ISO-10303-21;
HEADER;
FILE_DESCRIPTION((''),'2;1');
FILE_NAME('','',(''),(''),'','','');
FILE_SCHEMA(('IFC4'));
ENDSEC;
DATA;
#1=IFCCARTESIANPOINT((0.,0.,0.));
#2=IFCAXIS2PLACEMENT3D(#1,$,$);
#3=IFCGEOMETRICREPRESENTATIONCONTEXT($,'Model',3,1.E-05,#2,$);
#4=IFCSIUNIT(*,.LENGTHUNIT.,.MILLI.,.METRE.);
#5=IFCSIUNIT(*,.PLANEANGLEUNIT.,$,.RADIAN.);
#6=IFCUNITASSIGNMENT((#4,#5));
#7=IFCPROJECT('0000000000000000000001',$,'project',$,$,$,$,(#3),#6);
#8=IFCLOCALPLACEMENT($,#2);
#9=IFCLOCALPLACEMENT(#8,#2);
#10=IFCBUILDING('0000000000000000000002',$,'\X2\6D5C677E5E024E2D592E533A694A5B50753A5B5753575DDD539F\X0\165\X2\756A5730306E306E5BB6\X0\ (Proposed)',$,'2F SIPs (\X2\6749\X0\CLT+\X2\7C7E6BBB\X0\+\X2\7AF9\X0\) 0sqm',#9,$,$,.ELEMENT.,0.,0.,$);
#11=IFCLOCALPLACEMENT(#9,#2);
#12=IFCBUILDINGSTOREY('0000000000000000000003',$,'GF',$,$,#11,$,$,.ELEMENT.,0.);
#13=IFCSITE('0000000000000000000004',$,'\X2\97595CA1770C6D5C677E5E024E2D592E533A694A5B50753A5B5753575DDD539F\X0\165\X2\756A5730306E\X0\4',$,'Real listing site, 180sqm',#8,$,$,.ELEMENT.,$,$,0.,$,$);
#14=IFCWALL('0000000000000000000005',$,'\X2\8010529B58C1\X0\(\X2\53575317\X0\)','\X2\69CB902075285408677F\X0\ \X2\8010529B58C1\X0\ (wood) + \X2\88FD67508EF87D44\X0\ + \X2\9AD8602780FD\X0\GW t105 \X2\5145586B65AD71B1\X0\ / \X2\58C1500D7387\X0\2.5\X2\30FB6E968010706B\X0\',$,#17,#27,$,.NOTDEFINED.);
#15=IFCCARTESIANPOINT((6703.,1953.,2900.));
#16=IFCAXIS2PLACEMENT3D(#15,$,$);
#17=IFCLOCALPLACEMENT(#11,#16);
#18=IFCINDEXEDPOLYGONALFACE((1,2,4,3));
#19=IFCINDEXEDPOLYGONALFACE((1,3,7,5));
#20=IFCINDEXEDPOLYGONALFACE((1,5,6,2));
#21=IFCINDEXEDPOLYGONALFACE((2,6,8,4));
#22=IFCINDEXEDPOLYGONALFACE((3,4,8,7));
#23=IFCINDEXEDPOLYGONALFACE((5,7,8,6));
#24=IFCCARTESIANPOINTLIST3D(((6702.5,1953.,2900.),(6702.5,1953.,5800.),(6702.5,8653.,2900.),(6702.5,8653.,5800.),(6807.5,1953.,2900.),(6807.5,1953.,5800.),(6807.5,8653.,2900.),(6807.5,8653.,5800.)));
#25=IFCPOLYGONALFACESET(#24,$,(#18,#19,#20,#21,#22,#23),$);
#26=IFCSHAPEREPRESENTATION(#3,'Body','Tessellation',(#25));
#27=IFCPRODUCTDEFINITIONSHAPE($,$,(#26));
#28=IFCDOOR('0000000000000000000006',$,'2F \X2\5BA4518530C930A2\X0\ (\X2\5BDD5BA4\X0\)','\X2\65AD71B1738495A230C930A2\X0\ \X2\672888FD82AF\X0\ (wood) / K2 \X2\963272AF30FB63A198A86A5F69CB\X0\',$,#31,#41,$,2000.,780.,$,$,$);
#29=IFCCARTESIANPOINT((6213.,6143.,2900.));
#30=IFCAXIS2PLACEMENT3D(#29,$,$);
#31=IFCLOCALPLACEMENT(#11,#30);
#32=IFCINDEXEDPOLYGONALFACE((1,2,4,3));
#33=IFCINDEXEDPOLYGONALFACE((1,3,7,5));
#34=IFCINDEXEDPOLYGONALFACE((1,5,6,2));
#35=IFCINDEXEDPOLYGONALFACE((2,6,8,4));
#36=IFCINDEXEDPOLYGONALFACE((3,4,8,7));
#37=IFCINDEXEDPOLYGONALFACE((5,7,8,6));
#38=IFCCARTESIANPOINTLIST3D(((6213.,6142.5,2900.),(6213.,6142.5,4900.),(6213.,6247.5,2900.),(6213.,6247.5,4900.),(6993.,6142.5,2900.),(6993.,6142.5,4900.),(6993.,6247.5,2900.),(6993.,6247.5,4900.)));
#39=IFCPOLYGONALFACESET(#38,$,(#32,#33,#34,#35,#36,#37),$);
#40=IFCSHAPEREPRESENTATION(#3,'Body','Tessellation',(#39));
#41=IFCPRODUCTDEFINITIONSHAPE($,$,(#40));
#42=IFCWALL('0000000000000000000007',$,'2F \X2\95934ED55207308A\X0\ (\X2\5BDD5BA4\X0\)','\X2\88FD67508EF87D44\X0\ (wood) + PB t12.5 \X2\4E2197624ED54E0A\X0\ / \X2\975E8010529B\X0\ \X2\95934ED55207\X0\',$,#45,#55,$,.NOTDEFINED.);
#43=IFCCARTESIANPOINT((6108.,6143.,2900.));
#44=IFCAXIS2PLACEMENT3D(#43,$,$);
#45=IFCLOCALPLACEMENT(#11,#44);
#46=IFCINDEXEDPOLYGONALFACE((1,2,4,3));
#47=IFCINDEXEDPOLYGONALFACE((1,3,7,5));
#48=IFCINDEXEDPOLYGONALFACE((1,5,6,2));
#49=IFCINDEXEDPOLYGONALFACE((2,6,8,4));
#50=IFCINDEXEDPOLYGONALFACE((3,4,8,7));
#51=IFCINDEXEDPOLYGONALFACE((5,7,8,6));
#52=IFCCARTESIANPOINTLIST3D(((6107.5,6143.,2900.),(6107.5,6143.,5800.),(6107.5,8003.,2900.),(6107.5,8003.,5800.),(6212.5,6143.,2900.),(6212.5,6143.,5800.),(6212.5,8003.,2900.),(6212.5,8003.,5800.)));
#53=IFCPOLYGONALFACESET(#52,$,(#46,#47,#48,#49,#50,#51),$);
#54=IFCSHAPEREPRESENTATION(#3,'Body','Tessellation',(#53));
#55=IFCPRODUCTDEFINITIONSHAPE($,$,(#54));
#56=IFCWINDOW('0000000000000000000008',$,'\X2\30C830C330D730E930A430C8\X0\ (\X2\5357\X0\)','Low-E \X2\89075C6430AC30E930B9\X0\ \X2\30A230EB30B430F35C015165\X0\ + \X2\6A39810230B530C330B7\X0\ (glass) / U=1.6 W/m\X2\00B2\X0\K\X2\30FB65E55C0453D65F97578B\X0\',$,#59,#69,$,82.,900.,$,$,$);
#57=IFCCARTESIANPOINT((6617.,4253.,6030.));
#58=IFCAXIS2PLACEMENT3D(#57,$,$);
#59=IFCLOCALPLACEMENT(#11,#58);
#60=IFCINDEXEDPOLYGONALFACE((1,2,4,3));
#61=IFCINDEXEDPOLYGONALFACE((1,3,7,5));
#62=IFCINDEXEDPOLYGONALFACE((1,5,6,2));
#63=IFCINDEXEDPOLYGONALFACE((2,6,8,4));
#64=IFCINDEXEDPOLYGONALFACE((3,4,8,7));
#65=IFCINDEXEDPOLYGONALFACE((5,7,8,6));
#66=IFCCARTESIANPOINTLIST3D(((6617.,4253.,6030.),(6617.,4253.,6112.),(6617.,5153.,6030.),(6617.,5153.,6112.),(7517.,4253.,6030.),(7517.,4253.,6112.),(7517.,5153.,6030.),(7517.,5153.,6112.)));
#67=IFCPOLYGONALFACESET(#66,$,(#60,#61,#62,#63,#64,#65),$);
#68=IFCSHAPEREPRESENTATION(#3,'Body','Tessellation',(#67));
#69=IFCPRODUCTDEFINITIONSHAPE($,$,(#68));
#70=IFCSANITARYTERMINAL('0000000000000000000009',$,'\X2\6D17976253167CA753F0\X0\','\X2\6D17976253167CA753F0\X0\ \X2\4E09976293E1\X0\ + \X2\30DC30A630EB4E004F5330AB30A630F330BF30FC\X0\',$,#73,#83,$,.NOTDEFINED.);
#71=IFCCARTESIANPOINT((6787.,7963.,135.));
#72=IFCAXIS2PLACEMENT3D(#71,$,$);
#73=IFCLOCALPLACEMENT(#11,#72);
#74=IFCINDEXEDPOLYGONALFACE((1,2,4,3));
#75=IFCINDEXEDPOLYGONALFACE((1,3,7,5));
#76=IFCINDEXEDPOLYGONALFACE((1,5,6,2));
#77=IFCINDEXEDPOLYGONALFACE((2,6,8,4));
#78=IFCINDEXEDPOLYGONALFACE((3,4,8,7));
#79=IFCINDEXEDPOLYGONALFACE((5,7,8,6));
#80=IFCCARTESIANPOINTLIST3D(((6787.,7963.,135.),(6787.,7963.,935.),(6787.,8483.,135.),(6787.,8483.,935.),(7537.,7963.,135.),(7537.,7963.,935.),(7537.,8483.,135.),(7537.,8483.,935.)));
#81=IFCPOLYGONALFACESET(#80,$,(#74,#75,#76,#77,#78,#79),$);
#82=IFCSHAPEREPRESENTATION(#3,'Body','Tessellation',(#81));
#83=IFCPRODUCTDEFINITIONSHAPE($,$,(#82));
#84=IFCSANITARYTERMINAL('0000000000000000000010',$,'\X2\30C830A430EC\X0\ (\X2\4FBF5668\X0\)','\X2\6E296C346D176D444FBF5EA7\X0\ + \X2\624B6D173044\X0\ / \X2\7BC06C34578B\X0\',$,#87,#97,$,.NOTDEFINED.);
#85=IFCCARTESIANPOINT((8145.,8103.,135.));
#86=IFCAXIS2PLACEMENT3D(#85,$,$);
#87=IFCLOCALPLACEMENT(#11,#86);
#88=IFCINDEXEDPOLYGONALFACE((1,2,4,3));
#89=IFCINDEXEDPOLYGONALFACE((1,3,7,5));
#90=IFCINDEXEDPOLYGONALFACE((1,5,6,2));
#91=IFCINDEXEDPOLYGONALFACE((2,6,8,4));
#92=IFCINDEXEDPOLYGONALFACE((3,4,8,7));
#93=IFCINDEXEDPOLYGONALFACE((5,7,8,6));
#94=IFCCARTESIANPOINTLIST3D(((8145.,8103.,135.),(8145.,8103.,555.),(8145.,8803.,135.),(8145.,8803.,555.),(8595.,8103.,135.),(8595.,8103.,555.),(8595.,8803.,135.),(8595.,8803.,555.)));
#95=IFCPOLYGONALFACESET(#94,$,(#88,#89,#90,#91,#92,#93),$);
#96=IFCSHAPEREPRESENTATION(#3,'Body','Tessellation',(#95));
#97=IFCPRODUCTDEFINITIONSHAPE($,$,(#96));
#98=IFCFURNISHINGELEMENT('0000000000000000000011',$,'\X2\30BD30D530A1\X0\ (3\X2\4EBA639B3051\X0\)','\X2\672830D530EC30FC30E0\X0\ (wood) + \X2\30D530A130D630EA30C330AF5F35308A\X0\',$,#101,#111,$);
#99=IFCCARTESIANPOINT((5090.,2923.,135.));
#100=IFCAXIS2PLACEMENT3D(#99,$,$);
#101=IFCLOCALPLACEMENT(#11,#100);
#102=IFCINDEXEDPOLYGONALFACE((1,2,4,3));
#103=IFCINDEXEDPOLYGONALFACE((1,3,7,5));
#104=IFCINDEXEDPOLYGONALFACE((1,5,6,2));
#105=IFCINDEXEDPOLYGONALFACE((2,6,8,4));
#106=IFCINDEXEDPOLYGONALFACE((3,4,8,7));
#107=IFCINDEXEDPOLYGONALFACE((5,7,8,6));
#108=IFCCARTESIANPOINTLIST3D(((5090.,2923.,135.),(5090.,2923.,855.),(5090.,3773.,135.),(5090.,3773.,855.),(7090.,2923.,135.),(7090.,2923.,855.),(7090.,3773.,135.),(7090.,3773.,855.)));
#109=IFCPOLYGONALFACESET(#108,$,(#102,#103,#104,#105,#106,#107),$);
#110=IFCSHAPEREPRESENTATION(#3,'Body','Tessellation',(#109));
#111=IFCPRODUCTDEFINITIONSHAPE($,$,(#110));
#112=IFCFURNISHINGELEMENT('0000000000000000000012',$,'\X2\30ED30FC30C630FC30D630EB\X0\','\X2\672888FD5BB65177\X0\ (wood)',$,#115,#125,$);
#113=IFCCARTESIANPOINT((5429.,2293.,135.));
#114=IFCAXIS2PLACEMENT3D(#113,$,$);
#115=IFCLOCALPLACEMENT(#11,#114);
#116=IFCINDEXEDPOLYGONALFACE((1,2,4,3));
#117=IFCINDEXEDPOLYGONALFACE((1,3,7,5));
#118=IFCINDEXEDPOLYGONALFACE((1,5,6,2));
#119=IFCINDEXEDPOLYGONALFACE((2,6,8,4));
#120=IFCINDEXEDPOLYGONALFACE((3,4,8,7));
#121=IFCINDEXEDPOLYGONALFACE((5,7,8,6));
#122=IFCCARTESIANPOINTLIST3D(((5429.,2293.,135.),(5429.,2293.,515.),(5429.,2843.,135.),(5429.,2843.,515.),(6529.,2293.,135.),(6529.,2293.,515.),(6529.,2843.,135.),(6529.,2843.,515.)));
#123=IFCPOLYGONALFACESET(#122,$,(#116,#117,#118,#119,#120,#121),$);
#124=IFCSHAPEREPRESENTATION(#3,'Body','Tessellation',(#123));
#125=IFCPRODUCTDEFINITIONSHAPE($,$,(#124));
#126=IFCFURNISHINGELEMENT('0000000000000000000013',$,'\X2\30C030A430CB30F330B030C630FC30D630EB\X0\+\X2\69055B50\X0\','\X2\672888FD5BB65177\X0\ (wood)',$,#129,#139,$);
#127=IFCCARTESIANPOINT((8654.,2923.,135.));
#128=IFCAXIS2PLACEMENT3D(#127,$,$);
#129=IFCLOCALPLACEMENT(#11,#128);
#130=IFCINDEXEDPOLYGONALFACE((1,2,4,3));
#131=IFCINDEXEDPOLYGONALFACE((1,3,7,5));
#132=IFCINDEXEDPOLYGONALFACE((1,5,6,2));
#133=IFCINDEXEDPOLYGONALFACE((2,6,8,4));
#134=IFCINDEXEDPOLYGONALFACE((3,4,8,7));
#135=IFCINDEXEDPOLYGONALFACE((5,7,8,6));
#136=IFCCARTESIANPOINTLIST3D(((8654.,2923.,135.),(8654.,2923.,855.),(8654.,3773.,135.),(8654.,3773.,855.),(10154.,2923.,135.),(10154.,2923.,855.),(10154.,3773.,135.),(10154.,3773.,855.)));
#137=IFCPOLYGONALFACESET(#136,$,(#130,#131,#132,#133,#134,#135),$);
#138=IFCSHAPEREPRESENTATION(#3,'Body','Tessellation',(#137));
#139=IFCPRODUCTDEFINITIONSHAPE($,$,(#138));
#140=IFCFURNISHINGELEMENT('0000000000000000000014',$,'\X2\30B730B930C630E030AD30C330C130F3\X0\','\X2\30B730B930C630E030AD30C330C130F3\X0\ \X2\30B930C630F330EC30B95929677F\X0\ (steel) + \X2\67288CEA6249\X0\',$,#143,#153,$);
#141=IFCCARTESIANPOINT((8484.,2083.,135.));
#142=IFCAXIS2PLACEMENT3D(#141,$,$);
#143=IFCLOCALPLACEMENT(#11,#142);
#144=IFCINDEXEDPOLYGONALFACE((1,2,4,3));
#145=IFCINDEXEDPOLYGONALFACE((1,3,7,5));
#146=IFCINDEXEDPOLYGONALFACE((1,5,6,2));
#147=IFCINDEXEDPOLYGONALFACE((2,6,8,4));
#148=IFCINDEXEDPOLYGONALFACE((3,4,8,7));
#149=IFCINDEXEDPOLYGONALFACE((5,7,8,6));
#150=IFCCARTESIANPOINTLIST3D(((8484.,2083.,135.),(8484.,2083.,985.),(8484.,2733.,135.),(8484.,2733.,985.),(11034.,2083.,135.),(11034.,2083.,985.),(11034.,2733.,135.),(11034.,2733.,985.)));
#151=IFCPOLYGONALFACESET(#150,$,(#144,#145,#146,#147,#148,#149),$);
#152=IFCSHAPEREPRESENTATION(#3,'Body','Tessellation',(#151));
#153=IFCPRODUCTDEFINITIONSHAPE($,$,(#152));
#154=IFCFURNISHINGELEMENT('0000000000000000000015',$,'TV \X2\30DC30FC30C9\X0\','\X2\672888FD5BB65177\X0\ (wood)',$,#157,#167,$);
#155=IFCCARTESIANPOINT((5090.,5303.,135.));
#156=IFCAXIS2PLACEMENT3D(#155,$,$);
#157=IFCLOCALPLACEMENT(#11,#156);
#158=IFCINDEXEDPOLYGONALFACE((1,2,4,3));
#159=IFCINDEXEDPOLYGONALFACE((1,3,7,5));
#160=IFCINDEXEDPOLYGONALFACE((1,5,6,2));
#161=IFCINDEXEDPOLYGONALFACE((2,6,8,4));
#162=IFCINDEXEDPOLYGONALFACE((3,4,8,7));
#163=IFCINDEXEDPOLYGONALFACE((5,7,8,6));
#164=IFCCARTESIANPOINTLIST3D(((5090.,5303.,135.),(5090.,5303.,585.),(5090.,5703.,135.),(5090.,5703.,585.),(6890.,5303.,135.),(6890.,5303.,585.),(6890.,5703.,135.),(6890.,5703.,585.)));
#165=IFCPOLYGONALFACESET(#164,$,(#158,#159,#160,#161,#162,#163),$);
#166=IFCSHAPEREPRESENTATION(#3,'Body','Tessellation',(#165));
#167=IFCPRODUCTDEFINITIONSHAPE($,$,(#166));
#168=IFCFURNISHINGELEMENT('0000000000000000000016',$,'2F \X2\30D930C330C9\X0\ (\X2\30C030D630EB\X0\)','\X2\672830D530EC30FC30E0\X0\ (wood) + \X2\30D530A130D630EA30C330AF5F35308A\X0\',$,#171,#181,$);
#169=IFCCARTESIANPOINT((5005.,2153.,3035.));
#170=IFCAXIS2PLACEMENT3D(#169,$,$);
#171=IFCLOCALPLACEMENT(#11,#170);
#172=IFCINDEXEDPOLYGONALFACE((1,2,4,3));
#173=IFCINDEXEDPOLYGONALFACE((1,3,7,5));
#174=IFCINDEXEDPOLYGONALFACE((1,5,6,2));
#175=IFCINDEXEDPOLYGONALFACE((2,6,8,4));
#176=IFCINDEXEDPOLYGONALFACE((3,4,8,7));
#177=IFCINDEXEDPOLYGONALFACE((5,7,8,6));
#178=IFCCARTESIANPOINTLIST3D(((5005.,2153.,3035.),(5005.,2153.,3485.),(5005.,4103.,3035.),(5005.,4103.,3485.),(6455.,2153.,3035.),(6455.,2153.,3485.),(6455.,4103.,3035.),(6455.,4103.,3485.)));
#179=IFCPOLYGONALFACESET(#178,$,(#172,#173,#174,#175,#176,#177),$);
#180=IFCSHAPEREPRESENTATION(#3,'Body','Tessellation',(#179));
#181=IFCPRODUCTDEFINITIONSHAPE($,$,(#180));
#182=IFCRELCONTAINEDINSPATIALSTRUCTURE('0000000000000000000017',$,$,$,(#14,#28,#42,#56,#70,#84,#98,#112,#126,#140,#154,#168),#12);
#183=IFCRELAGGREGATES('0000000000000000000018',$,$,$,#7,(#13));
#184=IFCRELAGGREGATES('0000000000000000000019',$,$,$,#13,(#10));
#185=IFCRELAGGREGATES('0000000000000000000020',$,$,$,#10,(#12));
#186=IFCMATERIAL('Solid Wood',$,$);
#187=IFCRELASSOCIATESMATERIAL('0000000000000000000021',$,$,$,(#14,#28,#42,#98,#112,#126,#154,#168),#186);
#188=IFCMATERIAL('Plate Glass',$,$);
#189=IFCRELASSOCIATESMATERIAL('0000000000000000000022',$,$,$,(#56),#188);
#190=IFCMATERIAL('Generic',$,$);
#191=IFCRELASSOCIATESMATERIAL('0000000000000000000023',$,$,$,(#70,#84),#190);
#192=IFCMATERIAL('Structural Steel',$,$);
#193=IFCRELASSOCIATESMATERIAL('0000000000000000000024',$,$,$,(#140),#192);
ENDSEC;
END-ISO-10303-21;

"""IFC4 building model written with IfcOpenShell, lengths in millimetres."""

from ifc_helpers import new_model, si_unit, frame, frame_2d, origin, place, context, project, spatial, rectangle, extrude, material, element, fill, save


model = new_model("IFC4")

# Units and contexts
model_context = context("Model", 3, precision=1e-05, world=origin())
ifc_project = project(units=[si_unit("LENGTHUNIT", "METRE", prefix="MILLI"), si_unit("PLANEANGLEUNIT", "RADIAN")], contexts=[model_context])

# Site, building, storey
site_placement = place(None, origin())
site = spatial("IfcSite", under=ifc_project, at=site_placement, Name="静岡県浜松市中央区楊子町字南川原165番地の4", ObjectType="Real listing site, 180sqm", CompositionType="ELEMENT", RefElevation=0.0)
building_placement = place(site_placement, origin())
building = spatial("IfcBuilding", under=site, at=building_placement, Name="浜松市中央区楊子町字南川原165番地のの家 (Proposed)", ObjectType="2F SIPs (杉CLT+籾殻+竹) 0sqm", CompositionType="ELEMENT", ElevationOfRefHeight=0.0, ElevationOfTerrain=0.0)
storey_placement = place(building_placement, origin())
storey = spatial("IfcBuildingStorey", under=building, at=storey_placement, Name="GF", CompositionType="ELEMENT", Elevation=0.0)

# Shared definitions
ifc_material_1 = material(Name="Solid Wood")

# Wall, opening, door
wall_1_placement = place(storey_placement, frame((6703.0, 1953.0, 2900.0)))
wall_1 = element("IfcWall", 1, at=wall_1_placement, inside=storey, material=ifc_material_1, Name="耐力壁(南北)", Description="構造用合板 耐力壁 (wood) + 製材軸組 + 高性能GW t105 充填断熱 / 壁倍率2.5・準耐火", PredefinedType="NOTDEFINED", context=model_context, shape_type="SweptSolid", body=[
    extrude(rectangle(XDim=105.0, YDim=6700.0, at=frame_2d((52.0, 3350.0))), frame((6703.0, 1953.0, 2900.0)), (0.0, 0.0, 1.0), 2900.0),
])
opening_1_placement = place(storey_placement, frame((6213.0, 6143.0, 2900.0)))
opening_1 = element("IfcOpeningElement", 2, at=opening_1_placement, cuts=wall_1, PredefinedType="NOTDEFINED", context=model_context, shape_type="SweptSolid", body=[
    extrude(rectangle(XDim=780.0, YDim=105.0, at=frame_2d((390.0, 52.0))), frame((6213.0, 6143.0, 2900.0)), (0.0, 0.0, 1.0), 2000.0),
])
door_1_placement = place(storey_placement, frame((6213.0, 6143.0, 2900.0)))
door_1 = element("IfcDoor", 3, at=door_1_placement, inside=storey, material=ifc_material_1, Name="2F 室内ドア (寝室)", Description="断熱玄関ドア 木製芯 (wood) / K2 防犯・採風機構", OverallHeight=2000.0, OverallWidth=780.0, context=model_context, shape_type="SweptSolid", body=[
    extrude(rectangle(XDim=780.0, YDim=105.0, at=frame_2d((390.0, 52.0))), frame((6213.0, 6143.0, 2900.0)), (0.0, 0.0, 1.0), 2000.0),
])
fill(opening_1, door_1)

# Wall
wall_2_placement = place(storey_placement, frame((6108.0, 6143.0, 2900.0)))
element("IfcWall", 4, at=wall_2_placement, inside=storey, material=ifc_material_1, Name="2F 間仕切り (寝室)", Description="製材軸組 (wood) + PB t12.5 両面仕上 / 非耐力 間仕切", PredefinedType="NOTDEFINED", context=model_context, shape_type="SweptSolid", body=[
    extrude(rectangle(XDim=105.0, YDim=1860.0, at=frame_2d((52.0, 930.0))), frame((6108.0, 6143.0, 2900.0)), (0.0, 0.0, 1.0), 2900.0),
])

# Window
ifc_material_2 = material(Name="Plate Glass")
window_placement = place(storey_placement, frame((6617.0, 4253.0, 6030.0)))
element("IfcWindow", 5, at=window_placement, inside=storey, material=ifc_material_2, Name="トップライト (南)", Description="Low-E 複層ガラス アルゴン封入 + 樹脂サッシ (glass) / U=1.6 W/m²K・日射取得型", OverallHeight=82.0, OverallWidth=900.0, context=model_context, shape_type="SweptSolid", body=[
    extrude(rectangle(XDim=900.0, YDim=900.0, at=frame_2d((450.0, 450.0))), frame((6617.0, 4253.0, 6030.0)), (0.0, 0.0, 1.0), 82.0),
])

# Sanitary terminals
ifc_material_3 = material(Name="Generic")
sanitary_terminal_1_placement = place(storey_placement, frame((6787.0, 7963.0, 135.0)))
element("IfcSanitaryTerminal", 6, at=sanitary_terminal_1_placement, inside=storey, material=ifc_material_3, Name="洗面化粧台", Description="洗面化粧台 三面鏡 + ボウル一体カウンター", PredefinedType="NOTDEFINED", context=model_context, shape_type="SweptSolid", body=[
    extrude(rectangle(XDim=750.0, YDim=520.0, at=frame_2d((375.0, 260.0))), frame((6787.0, 7963.0, 135.0)), (0.0, 0.0, 1.0), 800.0),
])
sanitary_terminal_2_placement = place(storey_placement, frame((8145.0, 8103.0, 135.0)))
element("IfcSanitaryTerminal", 7, at=sanitary_terminal_2_placement, inside=storey, material=ifc_material_3, Name="トイレ (便器)", Description="温水洗浄便座 + 手洗い / 節水型", PredefinedType="NOTDEFINED", context=model_context, shape_type="SweptSolid", body=[
    extrude(rectangle(XDim=450.0, YDim=700.0, at=frame_2d((225.0, 350.0))), frame((8145.0, 8103.0, 135.0)), (0.0, 0.0, 1.0), 420.0),
])

# Furnishing elements
furnishing_1_placement = place(storey_placement, frame((5090.0, 2923.0, 135.0)))
element("IfcFurnishingElement", 8, at=furnishing_1_placement, inside=storey, material=ifc_material_1, Name="ソファ (3人掛け)", Description="木フレーム (wood) + ファブリック張り", context=model_context, shape_type="SweptSolid", body=[
    extrude(rectangle(XDim=2000.0, YDim=850.0, at=frame_2d((1000.0, 425.0))), frame((5090.0, 2923.0, 135.0)), (0.0, 0.0, 1.0), 720.0),
])
furnishing_2_placement = place(storey_placement, frame((5429.0, 2293.0, 135.0)))
element("IfcFurnishingElement", 9, at=furnishing_2_placement, inside=storey, material=ifc_material_1, Name="ローテーブル", Description="木製家具 (wood)", context=model_context, shape_type="SweptSolid", body=[
    extrude(rectangle(XDim=1100.0, YDim=550.0, at=frame_2d((550.0, 275.0))), frame((5429.0, 2293.0, 135.0)), (0.0, 0.0, 1.0), 380.0),
])
furnishing_3_placement = place(storey_placement, frame((8654.0, 2923.0, 135.0)))
element("IfcFurnishingElement", 10, at=furnishing_3_placement, inside=storey, material=ifc_material_1, Name="ダイニングテーブル+椅子", Description="木製家具 (wood)", context=model_context, shape_type="SweptSolid", body=[
    extrude(rectangle(XDim=1500.0, YDim=850.0, at=frame_2d((750.0, 425.0))), frame((8654.0, 2923.0, 135.0)), (0.0, 0.0, 1.0), 720.0),
])
ifc_material_4 = material(Name="Structural Steel")
furnishing_4_placement = place(storey_placement, frame((8484.0, 2083.0, 135.0)))
element("IfcFurnishingElement", 11, at=furnishing_4_placement, inside=storey, material=ifc_material_4, Name="システムキッチン", Description="システムキッチン ステンレス天板 (steel) + 木質扉", context=model_context, shape_type="SweptSolid", body=[
    extrude(rectangle(XDim=2550.0, YDim=650.0, at=frame_2d((1275.0, 325.0))), frame((8484.0, 2083.0, 135.0)), (0.0, 0.0, 1.0), 850.0),
])
furnishing_5_placement = place(storey_placement, frame((5090.0, 5303.0, 135.0)))
element("IfcFurnishingElement", 12, at=furnishing_5_placement, inside=storey, material=ifc_material_1, Name="TV ボード", Description="木製家具 (wood)", context=model_context, shape_type="SweptSolid", body=[
    extrude(rectangle(XDim=1800.0, YDim=400.0, at=frame_2d((900.0, 200.0))), frame((5090.0, 5303.0, 135.0)), (0.0, 0.0, 1.0), 450.0),
])
furnishing_6_placement = place(storey_placement, frame((5005.0, 2153.0, 3035.0)))
element("IfcFurnishingElement", 13, at=furnishing_6_placement, inside=storey, material=ifc_material_1, Name="2F ベッド (ダブル)", Description="木フレーム (wood) + ファブリック張り", context=model_context, shape_type="SweptSolid", body=[
    extrude(rectangle(XDim=1450.0, YDim=1950.0, at=frame_2d((725.0, 975.0))), frame((5005.0, 2153.0, 3035.0)), (0.0, 0.0, 1.0), 450.0),
])

save(model, "model.ifc")
